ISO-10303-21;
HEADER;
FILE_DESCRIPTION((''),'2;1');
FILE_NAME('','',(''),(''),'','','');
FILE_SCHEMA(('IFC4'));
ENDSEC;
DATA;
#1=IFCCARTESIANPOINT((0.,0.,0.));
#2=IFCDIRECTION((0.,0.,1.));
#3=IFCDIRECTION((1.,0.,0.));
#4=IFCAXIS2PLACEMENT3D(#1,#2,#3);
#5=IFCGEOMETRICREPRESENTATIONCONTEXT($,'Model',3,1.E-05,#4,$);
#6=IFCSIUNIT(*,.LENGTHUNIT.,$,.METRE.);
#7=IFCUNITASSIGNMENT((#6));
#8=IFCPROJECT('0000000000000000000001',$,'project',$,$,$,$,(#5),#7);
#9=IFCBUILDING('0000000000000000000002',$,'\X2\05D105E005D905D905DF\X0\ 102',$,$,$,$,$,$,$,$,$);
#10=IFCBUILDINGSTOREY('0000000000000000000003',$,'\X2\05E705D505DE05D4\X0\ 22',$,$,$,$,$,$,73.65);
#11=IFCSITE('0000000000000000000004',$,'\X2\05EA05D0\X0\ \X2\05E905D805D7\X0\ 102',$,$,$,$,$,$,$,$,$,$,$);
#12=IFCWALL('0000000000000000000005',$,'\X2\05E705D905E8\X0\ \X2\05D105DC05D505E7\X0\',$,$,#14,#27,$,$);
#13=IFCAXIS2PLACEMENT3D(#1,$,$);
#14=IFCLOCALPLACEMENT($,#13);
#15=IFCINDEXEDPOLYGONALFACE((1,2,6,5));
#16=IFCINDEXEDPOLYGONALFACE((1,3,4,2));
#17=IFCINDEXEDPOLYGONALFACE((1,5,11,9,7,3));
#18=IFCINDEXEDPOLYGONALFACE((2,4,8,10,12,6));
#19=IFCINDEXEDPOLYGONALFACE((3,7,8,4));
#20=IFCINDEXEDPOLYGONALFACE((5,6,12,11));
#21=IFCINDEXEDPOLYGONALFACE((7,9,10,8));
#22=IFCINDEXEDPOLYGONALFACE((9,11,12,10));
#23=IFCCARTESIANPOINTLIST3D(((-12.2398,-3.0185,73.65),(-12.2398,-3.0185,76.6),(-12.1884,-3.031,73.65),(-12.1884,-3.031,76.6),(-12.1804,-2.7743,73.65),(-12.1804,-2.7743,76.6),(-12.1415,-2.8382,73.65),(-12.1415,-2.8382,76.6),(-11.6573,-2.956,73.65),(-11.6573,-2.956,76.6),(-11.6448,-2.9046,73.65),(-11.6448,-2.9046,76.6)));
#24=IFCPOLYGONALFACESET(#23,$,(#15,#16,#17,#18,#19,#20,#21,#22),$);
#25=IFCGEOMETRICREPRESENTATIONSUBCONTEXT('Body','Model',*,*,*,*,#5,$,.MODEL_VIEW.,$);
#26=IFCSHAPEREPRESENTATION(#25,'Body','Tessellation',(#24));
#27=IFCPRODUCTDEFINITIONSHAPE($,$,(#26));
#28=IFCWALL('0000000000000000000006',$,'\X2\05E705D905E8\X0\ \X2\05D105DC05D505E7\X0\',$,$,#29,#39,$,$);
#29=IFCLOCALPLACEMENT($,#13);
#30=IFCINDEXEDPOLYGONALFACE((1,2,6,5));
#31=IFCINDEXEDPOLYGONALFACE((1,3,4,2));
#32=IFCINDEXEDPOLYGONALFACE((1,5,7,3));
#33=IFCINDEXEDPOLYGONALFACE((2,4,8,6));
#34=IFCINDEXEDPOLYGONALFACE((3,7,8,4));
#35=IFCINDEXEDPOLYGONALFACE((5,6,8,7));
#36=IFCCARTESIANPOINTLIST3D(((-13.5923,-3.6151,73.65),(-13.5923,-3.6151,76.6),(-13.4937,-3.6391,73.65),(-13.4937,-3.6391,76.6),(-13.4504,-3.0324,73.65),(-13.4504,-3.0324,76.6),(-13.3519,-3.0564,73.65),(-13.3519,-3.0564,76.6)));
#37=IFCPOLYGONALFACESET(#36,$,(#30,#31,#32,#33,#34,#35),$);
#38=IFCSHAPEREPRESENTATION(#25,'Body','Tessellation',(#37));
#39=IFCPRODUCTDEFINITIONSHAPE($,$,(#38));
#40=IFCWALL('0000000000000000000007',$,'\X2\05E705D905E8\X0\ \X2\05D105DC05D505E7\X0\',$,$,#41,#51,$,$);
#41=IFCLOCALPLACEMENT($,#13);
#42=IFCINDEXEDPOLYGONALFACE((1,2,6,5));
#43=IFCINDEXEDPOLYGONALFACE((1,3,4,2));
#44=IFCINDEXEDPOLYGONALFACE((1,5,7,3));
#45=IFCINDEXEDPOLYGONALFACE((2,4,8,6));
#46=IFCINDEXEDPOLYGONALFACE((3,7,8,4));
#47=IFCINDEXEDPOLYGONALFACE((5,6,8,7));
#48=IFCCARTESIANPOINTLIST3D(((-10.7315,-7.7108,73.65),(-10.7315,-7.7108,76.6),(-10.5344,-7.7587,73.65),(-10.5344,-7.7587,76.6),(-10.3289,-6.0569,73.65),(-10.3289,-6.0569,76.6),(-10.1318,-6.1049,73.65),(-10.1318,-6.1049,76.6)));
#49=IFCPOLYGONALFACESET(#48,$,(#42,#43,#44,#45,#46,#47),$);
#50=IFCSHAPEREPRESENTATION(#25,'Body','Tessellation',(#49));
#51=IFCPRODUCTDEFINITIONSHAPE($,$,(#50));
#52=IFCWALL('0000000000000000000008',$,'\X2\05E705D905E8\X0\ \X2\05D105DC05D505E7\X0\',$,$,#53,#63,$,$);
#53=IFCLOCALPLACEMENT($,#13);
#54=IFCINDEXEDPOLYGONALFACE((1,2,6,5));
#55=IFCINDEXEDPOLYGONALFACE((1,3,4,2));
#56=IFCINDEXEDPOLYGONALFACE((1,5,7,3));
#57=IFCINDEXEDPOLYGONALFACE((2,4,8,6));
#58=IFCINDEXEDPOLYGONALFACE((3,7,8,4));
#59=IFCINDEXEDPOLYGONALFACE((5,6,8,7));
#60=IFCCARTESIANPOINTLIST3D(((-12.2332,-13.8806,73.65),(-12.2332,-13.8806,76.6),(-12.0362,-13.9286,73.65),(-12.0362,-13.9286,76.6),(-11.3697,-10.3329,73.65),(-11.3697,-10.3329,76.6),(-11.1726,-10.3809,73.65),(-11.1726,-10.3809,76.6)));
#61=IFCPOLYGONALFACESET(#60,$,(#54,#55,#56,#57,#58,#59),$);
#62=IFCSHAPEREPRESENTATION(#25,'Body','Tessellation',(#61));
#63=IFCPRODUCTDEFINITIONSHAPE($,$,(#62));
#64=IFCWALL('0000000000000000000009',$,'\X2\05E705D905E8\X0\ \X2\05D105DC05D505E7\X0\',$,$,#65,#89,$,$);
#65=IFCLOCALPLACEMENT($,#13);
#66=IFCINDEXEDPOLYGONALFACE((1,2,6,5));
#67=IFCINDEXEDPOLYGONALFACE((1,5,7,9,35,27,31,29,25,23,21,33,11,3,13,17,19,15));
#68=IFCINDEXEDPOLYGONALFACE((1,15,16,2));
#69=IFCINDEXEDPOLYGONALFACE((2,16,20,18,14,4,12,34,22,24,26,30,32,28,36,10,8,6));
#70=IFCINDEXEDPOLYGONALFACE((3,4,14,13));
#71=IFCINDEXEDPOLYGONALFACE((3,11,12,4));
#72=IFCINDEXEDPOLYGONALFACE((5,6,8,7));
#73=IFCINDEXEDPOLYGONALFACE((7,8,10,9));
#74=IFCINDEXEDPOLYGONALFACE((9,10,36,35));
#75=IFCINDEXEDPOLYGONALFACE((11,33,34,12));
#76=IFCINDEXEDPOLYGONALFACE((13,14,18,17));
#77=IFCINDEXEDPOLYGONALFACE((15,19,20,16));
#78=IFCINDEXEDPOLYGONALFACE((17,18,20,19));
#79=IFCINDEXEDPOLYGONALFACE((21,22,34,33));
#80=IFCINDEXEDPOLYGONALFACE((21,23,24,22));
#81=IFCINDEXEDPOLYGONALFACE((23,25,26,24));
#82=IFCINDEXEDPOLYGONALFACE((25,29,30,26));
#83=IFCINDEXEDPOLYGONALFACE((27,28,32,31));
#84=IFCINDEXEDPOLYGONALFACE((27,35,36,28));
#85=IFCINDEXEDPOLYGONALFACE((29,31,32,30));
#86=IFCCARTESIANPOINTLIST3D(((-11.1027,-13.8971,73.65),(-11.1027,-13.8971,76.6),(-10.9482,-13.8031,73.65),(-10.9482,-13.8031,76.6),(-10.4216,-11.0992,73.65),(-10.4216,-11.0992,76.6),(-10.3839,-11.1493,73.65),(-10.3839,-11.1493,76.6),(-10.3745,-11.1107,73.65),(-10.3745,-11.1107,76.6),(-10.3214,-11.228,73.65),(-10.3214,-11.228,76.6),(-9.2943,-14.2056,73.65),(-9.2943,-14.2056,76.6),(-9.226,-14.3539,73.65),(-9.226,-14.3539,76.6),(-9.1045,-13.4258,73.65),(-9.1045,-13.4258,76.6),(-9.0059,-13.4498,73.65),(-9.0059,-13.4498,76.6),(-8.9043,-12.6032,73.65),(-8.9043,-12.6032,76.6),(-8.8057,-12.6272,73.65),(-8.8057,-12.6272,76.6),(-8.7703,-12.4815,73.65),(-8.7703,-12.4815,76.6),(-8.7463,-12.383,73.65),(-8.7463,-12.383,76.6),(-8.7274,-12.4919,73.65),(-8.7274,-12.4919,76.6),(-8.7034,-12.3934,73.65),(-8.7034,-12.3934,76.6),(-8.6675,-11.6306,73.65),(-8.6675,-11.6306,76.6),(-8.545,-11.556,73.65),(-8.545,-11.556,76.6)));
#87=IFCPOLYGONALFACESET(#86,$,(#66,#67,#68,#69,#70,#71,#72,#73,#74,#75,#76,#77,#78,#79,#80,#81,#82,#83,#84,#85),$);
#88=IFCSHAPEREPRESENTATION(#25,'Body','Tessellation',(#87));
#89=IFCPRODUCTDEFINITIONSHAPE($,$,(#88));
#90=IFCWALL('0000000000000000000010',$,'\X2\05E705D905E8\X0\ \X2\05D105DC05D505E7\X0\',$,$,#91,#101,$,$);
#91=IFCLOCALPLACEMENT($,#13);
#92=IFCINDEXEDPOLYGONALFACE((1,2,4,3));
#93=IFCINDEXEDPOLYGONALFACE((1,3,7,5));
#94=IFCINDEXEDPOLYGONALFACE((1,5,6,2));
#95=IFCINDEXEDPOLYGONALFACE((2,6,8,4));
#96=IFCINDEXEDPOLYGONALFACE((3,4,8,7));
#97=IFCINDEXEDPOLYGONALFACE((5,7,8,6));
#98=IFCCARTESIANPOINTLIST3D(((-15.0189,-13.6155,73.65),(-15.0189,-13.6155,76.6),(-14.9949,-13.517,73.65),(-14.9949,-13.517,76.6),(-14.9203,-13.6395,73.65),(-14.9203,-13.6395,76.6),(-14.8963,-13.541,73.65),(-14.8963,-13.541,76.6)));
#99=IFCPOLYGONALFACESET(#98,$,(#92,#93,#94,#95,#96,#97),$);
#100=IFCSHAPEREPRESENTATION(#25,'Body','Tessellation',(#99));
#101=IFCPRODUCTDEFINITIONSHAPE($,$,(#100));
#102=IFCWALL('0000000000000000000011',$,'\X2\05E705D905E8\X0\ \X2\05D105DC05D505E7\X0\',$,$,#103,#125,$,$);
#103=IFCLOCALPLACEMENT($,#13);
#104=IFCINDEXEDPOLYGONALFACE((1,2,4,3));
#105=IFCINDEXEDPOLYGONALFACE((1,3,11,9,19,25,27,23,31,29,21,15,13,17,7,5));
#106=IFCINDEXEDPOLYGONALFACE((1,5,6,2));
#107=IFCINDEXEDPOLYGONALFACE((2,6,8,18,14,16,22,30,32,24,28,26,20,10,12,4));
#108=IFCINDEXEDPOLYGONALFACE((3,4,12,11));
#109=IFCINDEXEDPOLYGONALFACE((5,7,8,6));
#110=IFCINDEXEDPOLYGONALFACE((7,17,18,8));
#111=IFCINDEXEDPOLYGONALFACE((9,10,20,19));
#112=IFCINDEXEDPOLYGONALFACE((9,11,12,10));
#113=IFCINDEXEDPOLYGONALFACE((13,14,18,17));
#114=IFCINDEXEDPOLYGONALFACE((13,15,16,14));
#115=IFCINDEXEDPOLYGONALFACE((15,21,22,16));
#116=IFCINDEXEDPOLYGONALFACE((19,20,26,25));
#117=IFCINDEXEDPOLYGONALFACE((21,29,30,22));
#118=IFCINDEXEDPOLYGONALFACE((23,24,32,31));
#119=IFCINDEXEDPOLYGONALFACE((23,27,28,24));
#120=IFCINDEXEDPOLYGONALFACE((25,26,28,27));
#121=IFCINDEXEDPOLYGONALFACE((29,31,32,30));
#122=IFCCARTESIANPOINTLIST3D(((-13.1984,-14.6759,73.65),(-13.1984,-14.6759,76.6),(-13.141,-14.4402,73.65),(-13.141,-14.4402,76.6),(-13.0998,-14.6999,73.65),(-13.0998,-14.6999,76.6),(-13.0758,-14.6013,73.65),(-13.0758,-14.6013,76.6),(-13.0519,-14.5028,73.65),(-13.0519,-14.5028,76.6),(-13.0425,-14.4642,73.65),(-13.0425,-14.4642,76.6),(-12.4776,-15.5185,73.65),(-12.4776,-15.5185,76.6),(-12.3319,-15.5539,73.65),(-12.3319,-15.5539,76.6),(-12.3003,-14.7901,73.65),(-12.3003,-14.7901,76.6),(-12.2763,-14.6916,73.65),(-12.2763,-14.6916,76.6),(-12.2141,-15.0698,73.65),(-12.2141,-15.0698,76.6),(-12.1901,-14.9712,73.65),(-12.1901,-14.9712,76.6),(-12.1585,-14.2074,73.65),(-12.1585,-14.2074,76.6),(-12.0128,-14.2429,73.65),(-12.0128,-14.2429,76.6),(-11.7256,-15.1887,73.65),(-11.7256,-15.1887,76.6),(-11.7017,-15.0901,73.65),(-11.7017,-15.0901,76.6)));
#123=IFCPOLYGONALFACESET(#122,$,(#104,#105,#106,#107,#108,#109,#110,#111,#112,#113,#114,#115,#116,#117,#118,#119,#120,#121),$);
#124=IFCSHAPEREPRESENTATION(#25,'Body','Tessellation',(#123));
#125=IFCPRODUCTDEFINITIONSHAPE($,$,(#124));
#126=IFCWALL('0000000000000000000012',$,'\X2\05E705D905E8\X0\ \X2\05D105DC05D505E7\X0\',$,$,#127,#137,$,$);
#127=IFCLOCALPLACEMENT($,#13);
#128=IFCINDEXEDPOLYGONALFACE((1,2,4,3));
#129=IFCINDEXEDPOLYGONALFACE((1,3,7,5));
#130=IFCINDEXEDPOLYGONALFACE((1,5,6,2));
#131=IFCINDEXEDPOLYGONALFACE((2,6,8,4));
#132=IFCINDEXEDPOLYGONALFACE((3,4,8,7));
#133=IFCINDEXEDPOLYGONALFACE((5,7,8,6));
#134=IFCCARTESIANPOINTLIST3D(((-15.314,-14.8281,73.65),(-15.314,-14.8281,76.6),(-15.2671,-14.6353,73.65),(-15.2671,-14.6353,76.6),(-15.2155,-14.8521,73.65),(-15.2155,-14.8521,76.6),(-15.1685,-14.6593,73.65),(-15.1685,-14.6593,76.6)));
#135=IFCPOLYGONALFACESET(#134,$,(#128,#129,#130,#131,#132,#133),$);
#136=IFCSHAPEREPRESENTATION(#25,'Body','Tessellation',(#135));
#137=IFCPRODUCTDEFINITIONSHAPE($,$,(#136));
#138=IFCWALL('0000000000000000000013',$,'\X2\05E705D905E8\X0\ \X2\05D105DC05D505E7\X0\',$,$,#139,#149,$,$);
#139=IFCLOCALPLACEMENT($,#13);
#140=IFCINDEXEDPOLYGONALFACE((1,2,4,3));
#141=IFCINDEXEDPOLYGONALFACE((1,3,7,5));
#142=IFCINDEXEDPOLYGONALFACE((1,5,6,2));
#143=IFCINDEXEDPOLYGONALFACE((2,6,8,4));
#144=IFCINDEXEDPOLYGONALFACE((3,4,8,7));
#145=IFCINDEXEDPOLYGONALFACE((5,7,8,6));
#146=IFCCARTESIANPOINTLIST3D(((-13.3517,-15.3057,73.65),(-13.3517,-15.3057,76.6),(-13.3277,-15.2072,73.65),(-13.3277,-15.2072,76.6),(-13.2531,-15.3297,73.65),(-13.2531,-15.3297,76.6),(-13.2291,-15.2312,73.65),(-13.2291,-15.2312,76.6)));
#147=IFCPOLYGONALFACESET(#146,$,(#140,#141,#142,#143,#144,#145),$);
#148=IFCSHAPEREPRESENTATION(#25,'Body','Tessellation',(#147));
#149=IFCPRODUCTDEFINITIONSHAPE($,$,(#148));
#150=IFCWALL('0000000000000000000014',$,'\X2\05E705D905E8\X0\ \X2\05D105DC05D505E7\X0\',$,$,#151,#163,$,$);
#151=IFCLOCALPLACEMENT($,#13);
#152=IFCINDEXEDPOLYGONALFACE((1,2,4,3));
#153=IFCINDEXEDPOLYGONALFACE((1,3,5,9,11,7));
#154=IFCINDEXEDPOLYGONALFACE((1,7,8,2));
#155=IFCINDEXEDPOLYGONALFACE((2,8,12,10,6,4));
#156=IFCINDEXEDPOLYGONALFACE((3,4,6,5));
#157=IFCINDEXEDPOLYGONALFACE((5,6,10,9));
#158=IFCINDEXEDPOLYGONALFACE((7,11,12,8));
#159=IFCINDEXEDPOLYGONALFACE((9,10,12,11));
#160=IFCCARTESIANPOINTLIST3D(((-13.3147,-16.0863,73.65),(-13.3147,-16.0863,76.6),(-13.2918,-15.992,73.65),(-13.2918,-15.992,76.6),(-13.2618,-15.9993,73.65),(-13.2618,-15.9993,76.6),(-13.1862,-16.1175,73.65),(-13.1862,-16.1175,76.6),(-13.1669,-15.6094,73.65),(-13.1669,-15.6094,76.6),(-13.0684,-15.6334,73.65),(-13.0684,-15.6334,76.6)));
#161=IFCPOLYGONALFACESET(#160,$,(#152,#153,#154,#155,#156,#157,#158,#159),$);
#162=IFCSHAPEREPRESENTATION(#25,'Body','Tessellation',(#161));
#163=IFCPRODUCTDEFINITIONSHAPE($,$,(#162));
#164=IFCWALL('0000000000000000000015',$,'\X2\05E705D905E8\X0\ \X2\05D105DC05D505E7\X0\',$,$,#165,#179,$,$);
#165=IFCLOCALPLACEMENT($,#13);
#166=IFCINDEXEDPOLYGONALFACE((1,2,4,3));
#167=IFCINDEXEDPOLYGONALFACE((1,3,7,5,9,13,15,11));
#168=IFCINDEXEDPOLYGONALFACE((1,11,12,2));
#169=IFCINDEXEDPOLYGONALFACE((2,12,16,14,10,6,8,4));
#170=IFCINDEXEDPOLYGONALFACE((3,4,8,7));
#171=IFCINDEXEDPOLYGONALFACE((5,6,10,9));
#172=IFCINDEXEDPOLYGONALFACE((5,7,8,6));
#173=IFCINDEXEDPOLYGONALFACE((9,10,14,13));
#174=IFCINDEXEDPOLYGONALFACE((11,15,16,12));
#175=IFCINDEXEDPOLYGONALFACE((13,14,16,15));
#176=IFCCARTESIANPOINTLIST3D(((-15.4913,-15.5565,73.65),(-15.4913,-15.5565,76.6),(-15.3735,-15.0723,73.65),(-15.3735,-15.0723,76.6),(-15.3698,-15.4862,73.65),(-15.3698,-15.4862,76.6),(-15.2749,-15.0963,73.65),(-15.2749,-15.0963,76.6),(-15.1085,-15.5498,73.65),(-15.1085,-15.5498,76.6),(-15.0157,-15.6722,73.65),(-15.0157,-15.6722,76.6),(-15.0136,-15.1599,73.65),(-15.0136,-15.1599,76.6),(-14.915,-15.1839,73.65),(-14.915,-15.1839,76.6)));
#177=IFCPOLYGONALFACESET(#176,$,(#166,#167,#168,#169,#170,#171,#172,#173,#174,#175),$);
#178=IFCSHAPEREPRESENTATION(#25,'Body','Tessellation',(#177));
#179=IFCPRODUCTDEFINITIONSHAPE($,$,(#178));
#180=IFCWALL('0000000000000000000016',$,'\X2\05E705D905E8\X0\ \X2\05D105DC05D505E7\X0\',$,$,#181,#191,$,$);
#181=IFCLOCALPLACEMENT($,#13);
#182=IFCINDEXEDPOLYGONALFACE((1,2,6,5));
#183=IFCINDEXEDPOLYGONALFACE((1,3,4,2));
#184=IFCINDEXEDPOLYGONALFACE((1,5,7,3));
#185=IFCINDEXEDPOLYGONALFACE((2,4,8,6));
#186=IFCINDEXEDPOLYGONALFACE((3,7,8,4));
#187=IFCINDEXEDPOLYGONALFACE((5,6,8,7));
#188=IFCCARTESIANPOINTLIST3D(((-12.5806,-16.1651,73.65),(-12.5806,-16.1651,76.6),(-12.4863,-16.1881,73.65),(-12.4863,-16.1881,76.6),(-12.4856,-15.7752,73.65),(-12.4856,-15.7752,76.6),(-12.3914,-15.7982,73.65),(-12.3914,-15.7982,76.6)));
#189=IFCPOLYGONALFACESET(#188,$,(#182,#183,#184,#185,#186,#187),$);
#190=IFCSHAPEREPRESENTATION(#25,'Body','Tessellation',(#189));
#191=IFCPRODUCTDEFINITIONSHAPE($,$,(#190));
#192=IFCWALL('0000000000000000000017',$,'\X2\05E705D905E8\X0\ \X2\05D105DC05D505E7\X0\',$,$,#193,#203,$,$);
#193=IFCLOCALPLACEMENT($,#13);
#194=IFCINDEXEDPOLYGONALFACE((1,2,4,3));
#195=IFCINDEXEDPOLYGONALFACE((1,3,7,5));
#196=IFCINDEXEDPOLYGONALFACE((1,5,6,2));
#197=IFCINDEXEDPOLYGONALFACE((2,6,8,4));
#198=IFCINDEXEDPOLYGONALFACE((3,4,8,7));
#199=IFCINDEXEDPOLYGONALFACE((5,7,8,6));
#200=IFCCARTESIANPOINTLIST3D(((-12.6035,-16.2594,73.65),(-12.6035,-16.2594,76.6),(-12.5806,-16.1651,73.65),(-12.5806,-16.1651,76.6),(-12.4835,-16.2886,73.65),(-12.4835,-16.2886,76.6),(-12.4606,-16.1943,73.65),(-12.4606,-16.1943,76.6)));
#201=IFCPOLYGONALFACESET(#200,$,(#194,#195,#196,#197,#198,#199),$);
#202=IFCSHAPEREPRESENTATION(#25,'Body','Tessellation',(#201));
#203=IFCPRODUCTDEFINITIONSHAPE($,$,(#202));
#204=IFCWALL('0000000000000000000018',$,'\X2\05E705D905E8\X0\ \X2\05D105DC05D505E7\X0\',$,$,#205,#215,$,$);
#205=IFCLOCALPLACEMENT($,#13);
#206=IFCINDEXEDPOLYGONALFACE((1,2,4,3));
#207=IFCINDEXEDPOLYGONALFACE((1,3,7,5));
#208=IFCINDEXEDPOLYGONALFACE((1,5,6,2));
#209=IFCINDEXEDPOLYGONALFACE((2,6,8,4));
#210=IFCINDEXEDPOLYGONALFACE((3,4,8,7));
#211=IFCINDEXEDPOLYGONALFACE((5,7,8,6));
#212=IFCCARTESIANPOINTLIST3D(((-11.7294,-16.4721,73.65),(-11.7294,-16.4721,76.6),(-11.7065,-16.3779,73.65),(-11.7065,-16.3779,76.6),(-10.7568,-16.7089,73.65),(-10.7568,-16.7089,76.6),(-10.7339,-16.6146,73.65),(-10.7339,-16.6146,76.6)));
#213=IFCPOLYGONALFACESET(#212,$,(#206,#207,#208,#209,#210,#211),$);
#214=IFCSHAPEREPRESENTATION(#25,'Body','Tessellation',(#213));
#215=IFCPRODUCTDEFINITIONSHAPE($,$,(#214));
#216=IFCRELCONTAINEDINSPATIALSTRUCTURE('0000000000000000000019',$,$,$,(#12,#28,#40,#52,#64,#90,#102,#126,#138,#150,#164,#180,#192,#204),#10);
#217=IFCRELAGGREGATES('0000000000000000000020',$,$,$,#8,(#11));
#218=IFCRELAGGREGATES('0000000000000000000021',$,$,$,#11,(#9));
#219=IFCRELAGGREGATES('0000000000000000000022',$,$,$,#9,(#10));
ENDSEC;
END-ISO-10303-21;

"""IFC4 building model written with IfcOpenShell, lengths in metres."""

from ifc_helpers import new_model, si_unit, frame, origin_with_axes, context, subcontext, project, spatial, polyline, outline, extrude, element, save


model = new_model("IFC4")

# Units and contexts
model_context = context("Model", 3, precision=1e-05, world=origin_with_axes())
body_context = subcontext(model_context, "Body", "Model", "MODEL_VIEW")
ifc_project = project(units=[si_unit("LENGTHUNIT", "METRE")], contexts=[model_context])

# Site, building, storey
site = spatial("IfcSite", under=ifc_project, Name="תא שטח 102")
building = spatial("IfcBuilding", under=site, Name="בניין 102")
storey = spatial("IfcBuildingStorey", under=building, Name="קומה 22", Elevation=73.65)

# Walls
element("IfcWall", 1, inside=storey, Name="קיר בלוק", context=body_context, shape_type="SweptSolid", body=[
    extrude(outline(polyline([(-12.1415, -2.8382), (-11.6573, -2.956), (-11.6448, -2.9046), (-12.1804, -2.7743), (-12.2398, -3.0185), (-12.1884, -3.031), (-12.1415, -2.8382)])), frame((0.0, 0.0, 73.65)), (0.0, 0.0, 1.0), 2.95),
])
element("IfcWall", 2, inside=storey, Name="קיר בלוק", context=body_context, shape_type="SweptSolid", body=[
    extrude(outline(polyline([(-13.4504, -3.0324), (-13.5923, -3.6151), (-13.4937, -3.6391), (-13.3519, -3.0564), (-13.4504, -3.0324)])), frame((0.0, 0.0, 73.65)), (0.0, 0.0, 1.0), 2.95),
])
element("IfcWall", 3, inside=storey, Name="קיר בלוק", context=body_context, shape_type="SweptSolid", body=[
    extrude(outline(polyline([(-10.7315, -7.7108), (-10.5344, -7.7587), (-10.1318, -6.1049), (-10.3289, -6.0569), (-10.7315, -7.7108)])), frame((0.0, 0.0, 73.65)), (0.0, 0.0, 1.0), 2.95),
])
element("IfcWall", 4, inside=storey, Name="קיר בלוק", context=body_context, shape_type="SweptSolid", body=[
    extrude(outline(polyline([(-12.2332, -13.8806), (-12.0362, -13.9286), (-11.1726, -10.3809), (-11.3697, -10.3329), (-12.2332, -13.8806)])), frame((0.0, 0.0, 73.65)), (0.0, 0.0, 1.0), 2.95),
])
element("IfcWall", 5, inside=storey, Name="קיר בלוק", context=body_context, shape_type="SweptSolid", body=[
    extrude(outline(polyline([(-11.1027, -13.8971), (-9.226, -14.3539), (-9.0059, -13.4498), (-9.1045, -13.4258), (-9.2943, -14.2056), (-10.9482, -13.8031), (-10.3214, -11.228), (-8.6675, -11.6306), (-8.9043, -12.6032), (-8.8057, -12.6272), (-8.7703, -12.4815), (-8.7274, -12.4919), (-8.7034, -12.3934), (-8.7463, -12.383), (-8.545, -11.556), (-10.3745, -11.1107), (-10.3839, -11.1493), (-10.4216, -11.0992), (-11.1027, -13.8971)])), frame((0.0, 0.0, 73.65)), (0.0, 0.0, 1.0), 2.95),
])
element("IfcWall", 6, inside=storey, Name="קיר בלוק", context=body_context, shape_type="SweptSolid", body=[
    extrude(outline(polyline([(-14.9949, -13.517), (-15.0189, -13.6155), (-14.9203, -13.6395), (-14.8963, -13.541), (-14.9949, -13.517)])), frame((0.0, 0.0, 73.65)), (0.0, 0.0, 1.0), 2.95),
])
element("IfcWall", 7, inside=storey, Name="קיר בלוק", context=body_context, shape_type="SweptSolid", body=[
    extrude(outline(polyline([(-13.0998, -14.6999), (-13.0758, -14.6013), (-12.3003, -14.7901), (-12.4776, -15.5185), (-12.3319, -15.5539), (-12.2141, -15.0698), (-11.7256, -15.1887), (-11.7017, -15.0901), (-12.1901, -14.9712), (-12.0128, -14.2429), (-12.1585, -14.2074), (-12.2763, -14.6916), (-13.0519, -14.5028), (-13.0425, -14.4642), (-13.141, -14.4402), (-13.1984, -14.6759), (-13.0998, -14.6999)])), frame((0.0, 0.0, 73.65)), (0.0, 0.0, 1.0), 2.95),
])
element("IfcWall", 8, inside=storey, Name="קיר בלוק", context=body_context, shape_type="SweptSolid", body=[
    extrude(outline(polyline([(-15.1685, -14.6593), (-15.2671, -14.6353), (-15.314, -14.8281), (-15.2155, -14.8521), (-15.1685, -14.6593)])), frame((0.0, 0.0, 73.65)), (0.0, 0.0, 1.0), 2.95),
])
element("IfcWall", 9, inside=storey, Name="קיר בלוק", context=body_context, shape_type="SweptSolid", body=[
    extrude(outline(polyline([(-13.3277, -15.2072), (-13.3517, -15.3057), (-13.2531, -15.3297), (-13.2291, -15.2312), (-13.3277, -15.2072)])), frame((0.0, 0.0, 73.65)), (0.0, 0.0, 1.0), 2.95),
])
element("IfcWall", 10, inside=storey, Name="קיר בלוק", context=body_context, shape_type="SweptSolid", body=[
    extrude(outline(polyline([(-13.3147, -16.0863), (-13.1862, -16.1175), (-13.0684, -15.6334), (-13.1669, -15.6094), (-13.2618, -15.9993), (-13.2918, -15.992), (-13.3147, -16.0863)])), frame((0.0, 0.0, 73.65)), (0.0, 0.0, 1.0), 2.95),
])
element("IfcWall", 11, inside=storey, Name="קיר בלוק", context=body_context, shape_type="SweptSolid", body=[
    extrude(outline(polyline([(-15.3735, -15.0723), (-15.4913, -15.5565), (-15.0157, -15.6722), (-14.915, -15.1839), (-15.0136, -15.1599), (-15.1085, -15.5498), (-15.3698, -15.4862), (-15.2749, -15.0963), (-15.3735, -15.0723)])), frame((0.0, 0.0, 73.65)), (0.0, 0.0, 1.0), 2.95),
])
element("IfcWall", 12, inside=storey, Name="קיר בלוק", context=body_context, shape_type="SweptSolid", body=[
    extrude(outline(polyline([(-12.4856, -15.7752), (-12.5806, -16.1651), (-12.4863, -16.1881), (-12.3914, -15.7982), (-12.4856, -15.7752)])), frame((0.0, 0.0, 73.65)), (0.0, 0.0, 1.0), 2.95),
])
element("IfcWall", 13, inside=storey, Name="קיר בלוק", context=body_context, shape_type="SweptSolid", body=[
    extrude(outline(polyline([(-12.4835, -16.2886), (-12.4606, -16.1943), (-12.5806, -16.1651), (-12.6035, -16.2594), (-12.4835, -16.2886)])), frame((0.0, 0.0, 73.65)), (0.0, 0.0, 1.0), 2.95),
])
element("IfcWall", 14, inside=storey, Name="קיר בלוק", context=body_context, shape_type="SweptSolid", body=[
    extrude(outline(polyline([(-11.7294, -16.4721), (-10.7568, -16.7089), (-10.7339, -16.6146), (-11.7065, -16.3779), (-11.7294, -16.4721)])), frame((0.0, 0.0, 73.65)), (0.0, 0.0, 1.0), 2.95),
])

save(model, "model.ifc")
